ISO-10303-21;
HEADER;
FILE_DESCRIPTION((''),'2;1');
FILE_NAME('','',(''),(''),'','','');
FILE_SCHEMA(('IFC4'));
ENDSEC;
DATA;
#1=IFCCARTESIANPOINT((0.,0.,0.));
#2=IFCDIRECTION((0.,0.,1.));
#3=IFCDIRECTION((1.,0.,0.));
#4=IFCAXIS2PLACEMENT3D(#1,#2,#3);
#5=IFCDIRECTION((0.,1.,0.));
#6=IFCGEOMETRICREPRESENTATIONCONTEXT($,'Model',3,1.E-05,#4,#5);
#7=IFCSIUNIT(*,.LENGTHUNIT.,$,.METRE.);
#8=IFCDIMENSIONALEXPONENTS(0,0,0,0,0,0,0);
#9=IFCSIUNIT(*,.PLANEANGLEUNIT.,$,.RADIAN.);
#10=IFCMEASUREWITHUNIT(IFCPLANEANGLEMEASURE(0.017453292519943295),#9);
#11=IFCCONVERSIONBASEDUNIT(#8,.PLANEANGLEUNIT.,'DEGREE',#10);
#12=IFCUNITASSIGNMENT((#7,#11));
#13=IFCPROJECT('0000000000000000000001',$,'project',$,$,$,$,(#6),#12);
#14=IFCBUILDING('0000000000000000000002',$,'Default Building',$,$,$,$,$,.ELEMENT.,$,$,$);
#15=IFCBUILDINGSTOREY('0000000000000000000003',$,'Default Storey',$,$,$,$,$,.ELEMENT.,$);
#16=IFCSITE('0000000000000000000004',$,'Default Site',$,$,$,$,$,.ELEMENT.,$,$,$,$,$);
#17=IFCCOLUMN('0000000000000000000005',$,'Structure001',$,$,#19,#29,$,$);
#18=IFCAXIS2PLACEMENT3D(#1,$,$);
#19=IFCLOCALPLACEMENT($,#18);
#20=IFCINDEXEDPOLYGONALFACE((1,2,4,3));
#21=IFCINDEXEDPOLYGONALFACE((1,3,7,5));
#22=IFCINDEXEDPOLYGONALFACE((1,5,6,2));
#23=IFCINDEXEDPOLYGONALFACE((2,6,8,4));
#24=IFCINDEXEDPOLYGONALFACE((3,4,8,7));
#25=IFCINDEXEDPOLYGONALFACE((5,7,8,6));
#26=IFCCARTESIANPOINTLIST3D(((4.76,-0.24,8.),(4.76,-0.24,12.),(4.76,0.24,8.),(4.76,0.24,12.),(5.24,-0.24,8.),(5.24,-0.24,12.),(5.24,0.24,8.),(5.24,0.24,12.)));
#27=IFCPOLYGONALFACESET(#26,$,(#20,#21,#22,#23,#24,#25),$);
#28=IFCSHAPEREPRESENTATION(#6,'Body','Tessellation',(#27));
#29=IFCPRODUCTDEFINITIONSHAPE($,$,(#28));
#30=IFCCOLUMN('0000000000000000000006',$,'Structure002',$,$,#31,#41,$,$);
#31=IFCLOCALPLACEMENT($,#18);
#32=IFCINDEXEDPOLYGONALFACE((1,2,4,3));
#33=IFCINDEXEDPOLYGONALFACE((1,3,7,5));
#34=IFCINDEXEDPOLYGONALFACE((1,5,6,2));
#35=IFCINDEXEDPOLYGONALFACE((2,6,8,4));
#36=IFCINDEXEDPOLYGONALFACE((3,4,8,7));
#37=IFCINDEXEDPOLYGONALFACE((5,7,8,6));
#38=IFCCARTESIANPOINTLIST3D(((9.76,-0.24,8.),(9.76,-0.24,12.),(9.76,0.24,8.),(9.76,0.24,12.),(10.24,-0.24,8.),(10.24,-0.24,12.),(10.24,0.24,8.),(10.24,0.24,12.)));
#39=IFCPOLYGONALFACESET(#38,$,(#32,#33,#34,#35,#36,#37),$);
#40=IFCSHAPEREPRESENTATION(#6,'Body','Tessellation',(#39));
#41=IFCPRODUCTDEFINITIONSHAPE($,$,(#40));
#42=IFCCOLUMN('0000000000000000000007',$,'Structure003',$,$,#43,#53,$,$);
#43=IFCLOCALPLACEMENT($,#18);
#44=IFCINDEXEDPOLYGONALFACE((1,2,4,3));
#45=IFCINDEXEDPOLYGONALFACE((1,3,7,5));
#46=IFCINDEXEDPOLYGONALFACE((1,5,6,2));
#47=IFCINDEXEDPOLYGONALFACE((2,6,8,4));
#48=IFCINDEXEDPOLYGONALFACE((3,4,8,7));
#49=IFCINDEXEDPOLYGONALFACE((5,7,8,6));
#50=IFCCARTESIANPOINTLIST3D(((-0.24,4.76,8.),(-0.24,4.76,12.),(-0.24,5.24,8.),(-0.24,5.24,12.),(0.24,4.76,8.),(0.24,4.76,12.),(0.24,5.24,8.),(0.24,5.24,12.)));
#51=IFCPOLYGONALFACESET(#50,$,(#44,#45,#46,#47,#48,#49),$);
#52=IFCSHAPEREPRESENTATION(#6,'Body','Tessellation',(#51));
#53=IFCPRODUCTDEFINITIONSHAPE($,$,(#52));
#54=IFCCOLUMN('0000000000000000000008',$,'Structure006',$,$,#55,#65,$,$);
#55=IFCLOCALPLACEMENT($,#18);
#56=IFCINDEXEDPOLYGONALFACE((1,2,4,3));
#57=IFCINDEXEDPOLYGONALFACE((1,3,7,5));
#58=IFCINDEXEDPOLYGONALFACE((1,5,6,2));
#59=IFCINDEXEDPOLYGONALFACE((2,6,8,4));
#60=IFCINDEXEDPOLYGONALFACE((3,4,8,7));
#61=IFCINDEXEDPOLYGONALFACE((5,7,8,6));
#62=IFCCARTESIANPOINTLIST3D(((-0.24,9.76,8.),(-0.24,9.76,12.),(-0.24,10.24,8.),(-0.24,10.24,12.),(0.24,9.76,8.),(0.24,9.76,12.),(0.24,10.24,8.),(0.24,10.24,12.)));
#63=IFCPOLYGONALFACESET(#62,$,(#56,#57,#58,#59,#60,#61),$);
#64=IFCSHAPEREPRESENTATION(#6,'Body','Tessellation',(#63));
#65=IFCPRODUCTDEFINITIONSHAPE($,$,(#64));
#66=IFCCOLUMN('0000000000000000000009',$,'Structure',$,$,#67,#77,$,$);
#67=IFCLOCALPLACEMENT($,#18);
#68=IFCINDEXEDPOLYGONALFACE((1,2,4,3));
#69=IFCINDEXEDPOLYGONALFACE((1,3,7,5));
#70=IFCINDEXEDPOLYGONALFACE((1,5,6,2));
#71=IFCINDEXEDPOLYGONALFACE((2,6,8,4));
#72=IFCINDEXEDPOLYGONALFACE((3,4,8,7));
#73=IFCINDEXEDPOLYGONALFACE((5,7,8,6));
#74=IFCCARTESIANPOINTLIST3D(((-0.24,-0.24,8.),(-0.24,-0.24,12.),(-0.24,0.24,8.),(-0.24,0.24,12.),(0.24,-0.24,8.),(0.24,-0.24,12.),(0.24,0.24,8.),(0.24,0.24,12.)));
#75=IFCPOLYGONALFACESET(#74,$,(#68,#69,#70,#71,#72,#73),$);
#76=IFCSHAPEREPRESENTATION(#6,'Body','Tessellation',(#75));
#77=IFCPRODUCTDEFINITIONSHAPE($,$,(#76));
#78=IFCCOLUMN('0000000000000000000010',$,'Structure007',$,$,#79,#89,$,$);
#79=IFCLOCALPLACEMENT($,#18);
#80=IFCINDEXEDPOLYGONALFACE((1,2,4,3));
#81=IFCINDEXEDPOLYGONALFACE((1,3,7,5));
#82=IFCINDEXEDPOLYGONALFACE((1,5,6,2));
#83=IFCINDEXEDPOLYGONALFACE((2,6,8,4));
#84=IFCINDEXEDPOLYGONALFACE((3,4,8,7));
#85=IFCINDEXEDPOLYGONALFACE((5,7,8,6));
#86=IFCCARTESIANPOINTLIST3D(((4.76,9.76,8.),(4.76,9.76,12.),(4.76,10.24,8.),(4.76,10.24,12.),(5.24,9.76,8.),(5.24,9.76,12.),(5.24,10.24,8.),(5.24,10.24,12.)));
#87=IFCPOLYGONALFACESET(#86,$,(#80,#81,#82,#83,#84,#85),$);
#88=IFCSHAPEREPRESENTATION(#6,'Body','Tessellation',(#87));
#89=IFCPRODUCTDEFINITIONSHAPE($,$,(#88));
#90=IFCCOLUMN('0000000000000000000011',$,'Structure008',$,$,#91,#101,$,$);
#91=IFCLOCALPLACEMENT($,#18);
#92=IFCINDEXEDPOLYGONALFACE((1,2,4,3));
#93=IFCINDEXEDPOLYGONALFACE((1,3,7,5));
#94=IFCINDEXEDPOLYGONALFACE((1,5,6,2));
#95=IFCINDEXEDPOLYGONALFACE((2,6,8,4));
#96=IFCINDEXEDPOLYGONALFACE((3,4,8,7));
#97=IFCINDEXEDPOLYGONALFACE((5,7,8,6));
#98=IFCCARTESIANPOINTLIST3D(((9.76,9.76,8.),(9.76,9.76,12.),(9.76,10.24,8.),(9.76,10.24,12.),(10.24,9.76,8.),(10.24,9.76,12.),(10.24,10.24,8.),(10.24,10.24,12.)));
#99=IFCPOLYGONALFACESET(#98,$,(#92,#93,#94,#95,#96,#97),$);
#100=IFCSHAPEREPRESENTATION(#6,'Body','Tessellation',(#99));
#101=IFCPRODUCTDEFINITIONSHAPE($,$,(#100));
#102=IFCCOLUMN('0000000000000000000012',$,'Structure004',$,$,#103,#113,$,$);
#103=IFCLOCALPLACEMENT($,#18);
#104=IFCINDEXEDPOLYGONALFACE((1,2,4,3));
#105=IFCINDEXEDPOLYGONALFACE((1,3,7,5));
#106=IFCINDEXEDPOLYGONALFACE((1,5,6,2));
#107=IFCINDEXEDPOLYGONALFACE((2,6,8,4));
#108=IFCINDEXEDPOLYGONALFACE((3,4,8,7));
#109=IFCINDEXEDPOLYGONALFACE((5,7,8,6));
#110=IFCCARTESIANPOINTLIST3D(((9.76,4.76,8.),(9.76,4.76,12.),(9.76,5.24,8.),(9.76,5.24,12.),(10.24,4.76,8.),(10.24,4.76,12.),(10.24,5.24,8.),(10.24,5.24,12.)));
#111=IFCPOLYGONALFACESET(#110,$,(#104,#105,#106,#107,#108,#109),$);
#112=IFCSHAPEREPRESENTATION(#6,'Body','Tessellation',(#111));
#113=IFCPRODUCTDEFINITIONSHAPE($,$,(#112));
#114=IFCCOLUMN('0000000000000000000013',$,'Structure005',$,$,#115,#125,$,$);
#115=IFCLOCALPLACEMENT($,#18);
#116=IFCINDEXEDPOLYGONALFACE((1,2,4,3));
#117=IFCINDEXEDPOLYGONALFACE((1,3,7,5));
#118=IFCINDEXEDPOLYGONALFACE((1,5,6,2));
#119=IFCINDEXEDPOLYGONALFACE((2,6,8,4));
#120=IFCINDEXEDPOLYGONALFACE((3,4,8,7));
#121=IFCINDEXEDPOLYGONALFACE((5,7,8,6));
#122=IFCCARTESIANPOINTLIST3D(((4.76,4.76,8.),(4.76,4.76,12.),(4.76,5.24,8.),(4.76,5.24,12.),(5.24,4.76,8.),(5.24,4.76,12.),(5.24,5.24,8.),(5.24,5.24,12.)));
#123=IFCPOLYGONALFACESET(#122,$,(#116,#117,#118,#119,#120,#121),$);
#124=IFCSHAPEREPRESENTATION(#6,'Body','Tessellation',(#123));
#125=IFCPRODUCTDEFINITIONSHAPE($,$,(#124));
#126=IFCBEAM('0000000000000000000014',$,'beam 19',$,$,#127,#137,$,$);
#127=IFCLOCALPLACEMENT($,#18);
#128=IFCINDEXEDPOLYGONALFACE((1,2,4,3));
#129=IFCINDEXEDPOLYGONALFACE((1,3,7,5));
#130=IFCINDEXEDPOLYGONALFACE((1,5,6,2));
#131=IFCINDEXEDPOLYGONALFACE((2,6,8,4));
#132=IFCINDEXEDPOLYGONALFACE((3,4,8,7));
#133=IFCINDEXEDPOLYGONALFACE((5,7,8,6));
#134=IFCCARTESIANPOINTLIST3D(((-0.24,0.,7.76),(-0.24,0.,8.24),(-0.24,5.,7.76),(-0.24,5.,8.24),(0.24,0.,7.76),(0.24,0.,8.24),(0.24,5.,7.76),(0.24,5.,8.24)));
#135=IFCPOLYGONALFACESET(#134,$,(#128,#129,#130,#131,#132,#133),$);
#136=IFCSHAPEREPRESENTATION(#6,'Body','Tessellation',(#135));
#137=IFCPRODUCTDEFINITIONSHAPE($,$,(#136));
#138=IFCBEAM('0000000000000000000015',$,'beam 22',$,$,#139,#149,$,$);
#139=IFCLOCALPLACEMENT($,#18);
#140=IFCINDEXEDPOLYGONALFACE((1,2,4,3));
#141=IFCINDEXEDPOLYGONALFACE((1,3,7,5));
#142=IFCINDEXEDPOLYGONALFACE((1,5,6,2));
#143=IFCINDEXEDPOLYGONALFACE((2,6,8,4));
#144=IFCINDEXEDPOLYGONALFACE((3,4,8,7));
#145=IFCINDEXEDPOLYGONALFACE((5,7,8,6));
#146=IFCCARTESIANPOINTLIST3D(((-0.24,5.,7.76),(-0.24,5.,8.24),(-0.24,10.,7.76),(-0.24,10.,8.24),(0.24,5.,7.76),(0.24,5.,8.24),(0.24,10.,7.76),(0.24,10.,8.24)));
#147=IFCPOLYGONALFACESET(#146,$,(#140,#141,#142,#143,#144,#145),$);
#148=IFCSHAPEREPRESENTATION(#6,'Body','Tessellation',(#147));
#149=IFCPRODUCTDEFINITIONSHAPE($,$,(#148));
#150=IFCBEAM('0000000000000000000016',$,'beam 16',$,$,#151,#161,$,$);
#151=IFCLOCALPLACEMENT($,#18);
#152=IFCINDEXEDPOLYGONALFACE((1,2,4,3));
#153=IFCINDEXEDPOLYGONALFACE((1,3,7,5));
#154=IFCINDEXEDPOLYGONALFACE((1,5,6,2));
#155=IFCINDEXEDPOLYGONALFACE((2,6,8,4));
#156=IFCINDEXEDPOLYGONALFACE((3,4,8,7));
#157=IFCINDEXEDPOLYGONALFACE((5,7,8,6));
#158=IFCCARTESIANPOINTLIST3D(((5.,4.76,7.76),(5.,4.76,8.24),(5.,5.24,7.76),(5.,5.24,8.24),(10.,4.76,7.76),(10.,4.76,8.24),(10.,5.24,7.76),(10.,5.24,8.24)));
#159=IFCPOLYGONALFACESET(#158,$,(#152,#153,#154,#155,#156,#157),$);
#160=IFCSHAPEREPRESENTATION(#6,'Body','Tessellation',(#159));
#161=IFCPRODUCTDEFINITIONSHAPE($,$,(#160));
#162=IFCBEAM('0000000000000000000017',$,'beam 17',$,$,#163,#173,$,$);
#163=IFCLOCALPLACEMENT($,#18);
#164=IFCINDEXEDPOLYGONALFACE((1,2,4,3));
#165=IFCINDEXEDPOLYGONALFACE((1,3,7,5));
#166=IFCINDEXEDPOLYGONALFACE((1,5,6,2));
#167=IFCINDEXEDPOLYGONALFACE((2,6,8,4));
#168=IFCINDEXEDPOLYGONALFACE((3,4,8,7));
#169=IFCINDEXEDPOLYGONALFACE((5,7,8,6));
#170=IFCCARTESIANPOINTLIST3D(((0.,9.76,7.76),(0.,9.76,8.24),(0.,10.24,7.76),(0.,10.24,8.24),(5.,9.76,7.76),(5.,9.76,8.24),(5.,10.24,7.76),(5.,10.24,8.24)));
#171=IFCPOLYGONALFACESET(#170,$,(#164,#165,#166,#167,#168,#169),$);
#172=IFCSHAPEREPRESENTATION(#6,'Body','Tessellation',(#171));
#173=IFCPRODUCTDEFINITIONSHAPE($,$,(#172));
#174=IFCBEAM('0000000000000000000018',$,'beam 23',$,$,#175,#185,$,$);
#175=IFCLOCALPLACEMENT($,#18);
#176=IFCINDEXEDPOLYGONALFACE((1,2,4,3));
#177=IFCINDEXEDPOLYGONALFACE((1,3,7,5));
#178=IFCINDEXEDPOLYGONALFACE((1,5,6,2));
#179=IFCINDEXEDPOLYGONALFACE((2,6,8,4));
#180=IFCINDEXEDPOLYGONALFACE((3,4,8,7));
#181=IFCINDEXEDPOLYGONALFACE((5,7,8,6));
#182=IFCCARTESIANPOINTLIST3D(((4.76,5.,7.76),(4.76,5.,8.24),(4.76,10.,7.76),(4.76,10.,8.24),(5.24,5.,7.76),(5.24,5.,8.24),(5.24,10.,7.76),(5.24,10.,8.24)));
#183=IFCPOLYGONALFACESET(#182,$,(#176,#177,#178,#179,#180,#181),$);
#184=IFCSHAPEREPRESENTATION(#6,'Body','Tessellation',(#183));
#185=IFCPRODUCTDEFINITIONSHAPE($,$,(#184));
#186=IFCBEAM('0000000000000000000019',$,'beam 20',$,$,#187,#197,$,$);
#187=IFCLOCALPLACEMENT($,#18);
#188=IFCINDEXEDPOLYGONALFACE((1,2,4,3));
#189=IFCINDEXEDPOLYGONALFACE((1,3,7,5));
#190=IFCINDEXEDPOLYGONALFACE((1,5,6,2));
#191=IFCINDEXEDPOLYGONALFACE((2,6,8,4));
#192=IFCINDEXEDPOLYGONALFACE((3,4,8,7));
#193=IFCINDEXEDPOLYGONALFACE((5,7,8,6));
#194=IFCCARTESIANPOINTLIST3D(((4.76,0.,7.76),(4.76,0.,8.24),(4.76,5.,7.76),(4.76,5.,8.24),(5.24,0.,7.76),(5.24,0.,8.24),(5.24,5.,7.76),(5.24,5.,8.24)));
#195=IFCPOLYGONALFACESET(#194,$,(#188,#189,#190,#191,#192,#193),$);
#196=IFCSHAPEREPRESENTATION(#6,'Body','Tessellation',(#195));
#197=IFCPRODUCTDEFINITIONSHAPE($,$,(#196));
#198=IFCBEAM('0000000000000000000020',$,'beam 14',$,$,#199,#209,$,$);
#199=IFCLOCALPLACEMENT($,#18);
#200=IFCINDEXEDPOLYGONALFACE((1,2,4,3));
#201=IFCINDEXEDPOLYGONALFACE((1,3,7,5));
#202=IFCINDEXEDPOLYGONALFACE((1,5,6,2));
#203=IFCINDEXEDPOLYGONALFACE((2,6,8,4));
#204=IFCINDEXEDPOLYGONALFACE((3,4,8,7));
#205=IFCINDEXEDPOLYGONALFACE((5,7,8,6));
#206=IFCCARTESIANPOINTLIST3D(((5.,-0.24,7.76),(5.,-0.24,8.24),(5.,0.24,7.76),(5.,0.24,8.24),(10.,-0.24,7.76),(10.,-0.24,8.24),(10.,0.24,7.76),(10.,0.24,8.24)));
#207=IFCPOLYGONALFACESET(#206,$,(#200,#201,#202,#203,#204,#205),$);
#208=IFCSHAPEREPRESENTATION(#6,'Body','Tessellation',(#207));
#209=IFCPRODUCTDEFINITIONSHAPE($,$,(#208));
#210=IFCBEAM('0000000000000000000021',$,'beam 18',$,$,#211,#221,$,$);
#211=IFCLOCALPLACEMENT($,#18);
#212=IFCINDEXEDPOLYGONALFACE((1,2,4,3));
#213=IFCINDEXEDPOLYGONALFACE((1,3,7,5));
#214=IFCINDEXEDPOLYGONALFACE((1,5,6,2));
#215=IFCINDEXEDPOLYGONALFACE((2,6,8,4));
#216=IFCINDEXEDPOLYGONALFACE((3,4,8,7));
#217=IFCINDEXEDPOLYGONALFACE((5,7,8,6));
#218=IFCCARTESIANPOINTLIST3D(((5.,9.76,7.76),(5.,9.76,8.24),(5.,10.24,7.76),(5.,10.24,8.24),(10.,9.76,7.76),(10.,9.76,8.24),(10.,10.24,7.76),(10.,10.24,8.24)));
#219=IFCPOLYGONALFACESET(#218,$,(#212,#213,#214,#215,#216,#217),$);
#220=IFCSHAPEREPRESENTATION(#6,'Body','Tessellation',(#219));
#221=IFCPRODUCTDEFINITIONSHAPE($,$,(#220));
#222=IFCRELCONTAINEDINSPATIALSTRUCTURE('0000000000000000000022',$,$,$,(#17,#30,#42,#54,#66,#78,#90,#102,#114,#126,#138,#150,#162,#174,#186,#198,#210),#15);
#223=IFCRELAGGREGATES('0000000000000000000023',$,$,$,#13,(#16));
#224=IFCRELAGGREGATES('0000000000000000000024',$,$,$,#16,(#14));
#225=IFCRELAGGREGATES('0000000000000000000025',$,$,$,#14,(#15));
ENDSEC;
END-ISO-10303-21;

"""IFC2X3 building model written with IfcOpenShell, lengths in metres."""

from ifc_helpers import new_model, entity, si_unit, converted_unit, direction, frame, origin_with_axes, place, context, project, spatial, polyline, outline, extrude, element, save


model = new_model("IFC2X3")

# Units and contexts
model_context = context("Model", 3, precision=1e-05, world=origin_with_axes(), true_north=direction((0.0, 1.0, 0.0)))
ifc_project = project(units=[si_unit("LENGTHUNIT", "METRE"), converted_unit("PLANEANGLEUNIT", "DEGREE", entity("IfcPlaneAngleMeasure", 0.017453292519943295), si_unit("PLANEANGLEUNIT", "RADIAN"), dimensions=[0, 0, 0, 0, 0, 0, 0])], contexts=[model_context])

# Site, building, storey
site = spatial("IfcSite", under=ifc_project, Name="Default Site", CompositionType="ELEMENT")
building = spatial("IfcBuilding", under=site, Name="Default Building", CompositionType="ELEMENT")
storey = spatial("IfcBuildingStorey", under=building, Name="Default Storey", CompositionType="ELEMENT")

# Columns
placement = place(None, origin_with_axes())
element("IfcColumn", 1, at=placement, inside=storey, Name="Structure001", context=model_context, shape_type="SweptSolid", body=[
    extrude(outline(polyline([(-0.24, -0.24), (0.24, -0.24), (0.24, 0.24), (-0.24, 0.24), (-0.24, -0.24)])), frame((5.0, 0.0, 8.0), z_axis=(0.0, 0.0, 1.0), x_axis=(1.0, 0.0, 0.0)), (0.0, 0.0, 1.0), 4.0),
])
element("IfcColumn", 2, at=placement, inside=storey, Name="Structure002", context=model_context, shape_type="SweptSolid", body=[
    extrude(outline(polyline([(-0.24, -0.24), (0.24, -0.24), (0.24, 0.24), (-0.24, 0.24), (-0.24, -0.24)])), frame((10.0, 0.0, 8.0), z_axis=(0.0, 0.0, 1.0), x_axis=(1.0, 0.0, 0.0)), (0.0, 0.0, 1.0), 4.0),
])
element("IfcColumn", 3, at=placement, inside=storey, Name="Structure003", context=model_context, shape_type="SweptSolid", body=[
    extrude(outline(polyline([(-0.24, -0.24), (0.24, -0.24), (0.24, 0.24), (-0.24, 0.24), (-0.24, -0.24)])), frame((0.0, 5.0, 8.0), z_axis=(0.0, 0.0, 1.0), x_axis=(1.0, 0.0, 0.0)), (0.0, 0.0, 1.0), 4.0),
])
element("IfcColumn", 4, at=placement, inside=storey, Name="Structure006", context=model_context, shape_type="SweptSolid", body=[
    extrude(outline(polyline([(-0.24, -0.24), (0.24, -0.24), (0.24, 0.24), (-0.24, 0.24), (-0.24, -0.24)])), frame((0.0, 10.0, 8.0), z_axis=(0.0, 0.0, 1.0), x_axis=(1.0, 0.0, 0.0)), (0.0, 0.0, 1.0), 4.0),
])
element("IfcColumn", 5, at=placement, inside=storey, Name="Structure", context=model_context, shape_type="SweptSolid", body=[
    extrude(outline(polyline([(-0.24, -0.24), (0.24, -0.24), (0.24, 0.24), (-0.24, 0.24), (-0.24, -0.24)])), frame((0.0, 0.0, 8.0), z_axis=(0.0, 0.0, 1.0), x_axis=(1.0, 0.0, 0.0)), (0.0, 0.0, 1.0), 4.0),
])
element("IfcColumn", 6, at=placement, inside=storey, Name="Structure007", context=model_context, shape_type="SweptSolid", body=[
    extrude(outline(polyline([(-0.24, -0.24), (0.24, -0.24), (0.24, 0.24), (-0.24, 0.24), (-0.24, -0.24)])), frame((5.0, 10.0, 8.0), z_axis=(0.0, 0.0, 1.0), x_axis=(1.0, 0.0, 0.0)), (0.0, 0.0, 1.0), 4.0),
])
element("IfcColumn", 7, at=placement, inside=storey, Name="Structure008", context=model_context, shape_type="SweptSolid", body=[
    extrude(outline(polyline([(-0.24, -0.24), (0.24, -0.24), (0.24, 0.24), (-0.24, 0.24), (-0.24, -0.24)])), frame((10.0, 10.0, 8.0), z_axis=(0.0, 0.0, 1.0), x_axis=(1.0, 0.0, 0.0)), (0.0, 0.0, 1.0), 4.0),
])
element("IfcColumn", 8, at=placement, inside=storey, Name="Structure004", context=model_context, shape_type="SweptSolid", body=[
    extrude(outline(polyline([(-0.24, -0.24), (0.24, -0.24), (0.24, 0.24), (-0.24, 0.24), (-0.24, -0.24)])), frame((10.0, 5.0, 8.0), z_axis=(0.0, 0.0, 1.0), x_axis=(1.0, 0.0, 0.0)), (0.0, 0.0, 1.0), 4.0),
])
element("IfcColumn", 9, at=placement, inside=storey, Name="Structure005", context=model_context, shape_type="SweptSolid", body=[
    extrude(outline(polyline([(-0.24, -0.24), (0.24, -0.24), (0.24, 0.24), (-0.24, 0.24), (-0.24, -0.24)])), frame((5.0, 5.0, 8.0), z_axis=(0.0, 0.0, 1.0), x_axis=(1.0, 0.0, 0.0)), (0.0, 0.0, 1.0), 4.0),
])

# Beams
element("IfcBeam", 10, at=placement, inside=storey, Name="beam 19", context=model_context, shape_type="SweptSolid", body=[
    extrude(outline(polyline([(0.24, -0.24), (0.24, 0.24), (-0.24, 0.24), (-0.24, -0.24), (0.24, -0.24)])), frame((0.0, 0.0, 8.0), z_axis=(0.0, 1.0, 0.0), x_axis=(0.0, 0.0, -1.0)), (0.0, 0.0, 1.0), 5.0),
])
element("IfcBeam", 11, at=placement, inside=storey, Name="beam 22", context=model_context, shape_type="SweptSolid", body=[
    extrude(outline(polyline([(0.24, -0.24), (0.24, 0.24), (-0.24, 0.24), (-0.24, -0.24), (0.24, -0.24)])), frame((0.0, 5.0, 8.0), z_axis=(0.0, 1.0, 0.0), x_axis=(0.0, 0.0, -1.0)), (0.0, 0.0, 1.0), 5.0),
])
element("IfcBeam", 12, at=placement, inside=storey, Name="beam 16", context=model_context, shape_type="SweptSolid", body=[
    extrude(outline(polyline([(0.24, -0.24), (0.24, 0.24), (-0.24, 0.24), (-0.24, -0.24), (0.24, -0.24)])), frame((5.0, 5.0, 8.0), z_axis=(1.0, 0.0, 0.0), x_axis=(0.0, 0.0, -1.0)), (0.0, 0.0, 1.0), 5.0),
])
element("IfcBeam", 13, at=placement, inside=storey, Name="beam 17", context=model_context, shape_type="SweptSolid", body=[
    extrude(outline(polyline([(0.24, -0.24), (0.24, 0.24), (-0.24, 0.24), (-0.24, -0.24), (0.24, -0.24)])), frame((0.0, 10.0, 8.0), z_axis=(1.0, 0.0, 0.0), x_axis=(0.0, 0.0, -1.0)), (0.0, 0.0, 1.0), 5.0),
])
element("IfcBeam", 14, at=placement, inside=storey, Name="beam 23", context=model_context, shape_type="SweptSolid", body=[
    extrude(outline(polyline([(0.24, -0.24), (0.24, 0.24), (-0.24, 0.24), (-0.24, -0.24), (0.24, -0.24)])), frame((5.0, 5.0, 8.0), z_axis=(0.0, 1.0, 0.0), x_axis=(0.0, 0.0, -1.0)), (0.0, 0.0, 1.0), 5.0),
])
element("IfcBeam", 15, at=placement, inside=storey, Name="beam 20", context=model_context, shape_type="SweptSolid", body=[
    extrude(outline(polyline([(0.24, -0.24), (0.24, 0.24), (-0.24, 0.24), (-0.24, -0.24), (0.24, -0.24)])), frame((5.0, 0.0, 8.0), z_axis=(0.0, 1.0, 0.0), x_axis=(0.0, 0.0, -1.0)), (0.0, 0.0, 1.0), 5.0),
])
element("IfcBeam", 16, at=placement, inside=storey, Name="beam 14", context=model_context, shape_type="SweptSolid", body=[
    extrude(outline(polyline([(0.24, -0.24), (0.24, 0.24), (-0.24, 0.24), (-0.24, -0.24), (0.24, -0.24)])), frame((5.0, 0.0, 8.0), z_axis=(1.0, 0.0, 0.0), x_axis=(0.0, 0.0, -1.0)), (0.0, 0.0, 1.0), 5.0),
])
element("IfcBeam", 17, at=placement, inside=storey, Name="beam 18", context=model_context, shape_type="SweptSolid", body=[
    extrude(outline(polyline([(0.24, -0.24), (0.24, 0.24), (-0.24, 0.24), (-0.24, -0.24), (0.24, -0.24)])), frame((5.0, 10.0, 8.0), z_axis=(1.0, 0.0, 0.0), x_axis=(0.0, 0.0, -1.0)), (0.0, 0.0, 1.0), 5.0),
])

save(model, "model.ifc")
